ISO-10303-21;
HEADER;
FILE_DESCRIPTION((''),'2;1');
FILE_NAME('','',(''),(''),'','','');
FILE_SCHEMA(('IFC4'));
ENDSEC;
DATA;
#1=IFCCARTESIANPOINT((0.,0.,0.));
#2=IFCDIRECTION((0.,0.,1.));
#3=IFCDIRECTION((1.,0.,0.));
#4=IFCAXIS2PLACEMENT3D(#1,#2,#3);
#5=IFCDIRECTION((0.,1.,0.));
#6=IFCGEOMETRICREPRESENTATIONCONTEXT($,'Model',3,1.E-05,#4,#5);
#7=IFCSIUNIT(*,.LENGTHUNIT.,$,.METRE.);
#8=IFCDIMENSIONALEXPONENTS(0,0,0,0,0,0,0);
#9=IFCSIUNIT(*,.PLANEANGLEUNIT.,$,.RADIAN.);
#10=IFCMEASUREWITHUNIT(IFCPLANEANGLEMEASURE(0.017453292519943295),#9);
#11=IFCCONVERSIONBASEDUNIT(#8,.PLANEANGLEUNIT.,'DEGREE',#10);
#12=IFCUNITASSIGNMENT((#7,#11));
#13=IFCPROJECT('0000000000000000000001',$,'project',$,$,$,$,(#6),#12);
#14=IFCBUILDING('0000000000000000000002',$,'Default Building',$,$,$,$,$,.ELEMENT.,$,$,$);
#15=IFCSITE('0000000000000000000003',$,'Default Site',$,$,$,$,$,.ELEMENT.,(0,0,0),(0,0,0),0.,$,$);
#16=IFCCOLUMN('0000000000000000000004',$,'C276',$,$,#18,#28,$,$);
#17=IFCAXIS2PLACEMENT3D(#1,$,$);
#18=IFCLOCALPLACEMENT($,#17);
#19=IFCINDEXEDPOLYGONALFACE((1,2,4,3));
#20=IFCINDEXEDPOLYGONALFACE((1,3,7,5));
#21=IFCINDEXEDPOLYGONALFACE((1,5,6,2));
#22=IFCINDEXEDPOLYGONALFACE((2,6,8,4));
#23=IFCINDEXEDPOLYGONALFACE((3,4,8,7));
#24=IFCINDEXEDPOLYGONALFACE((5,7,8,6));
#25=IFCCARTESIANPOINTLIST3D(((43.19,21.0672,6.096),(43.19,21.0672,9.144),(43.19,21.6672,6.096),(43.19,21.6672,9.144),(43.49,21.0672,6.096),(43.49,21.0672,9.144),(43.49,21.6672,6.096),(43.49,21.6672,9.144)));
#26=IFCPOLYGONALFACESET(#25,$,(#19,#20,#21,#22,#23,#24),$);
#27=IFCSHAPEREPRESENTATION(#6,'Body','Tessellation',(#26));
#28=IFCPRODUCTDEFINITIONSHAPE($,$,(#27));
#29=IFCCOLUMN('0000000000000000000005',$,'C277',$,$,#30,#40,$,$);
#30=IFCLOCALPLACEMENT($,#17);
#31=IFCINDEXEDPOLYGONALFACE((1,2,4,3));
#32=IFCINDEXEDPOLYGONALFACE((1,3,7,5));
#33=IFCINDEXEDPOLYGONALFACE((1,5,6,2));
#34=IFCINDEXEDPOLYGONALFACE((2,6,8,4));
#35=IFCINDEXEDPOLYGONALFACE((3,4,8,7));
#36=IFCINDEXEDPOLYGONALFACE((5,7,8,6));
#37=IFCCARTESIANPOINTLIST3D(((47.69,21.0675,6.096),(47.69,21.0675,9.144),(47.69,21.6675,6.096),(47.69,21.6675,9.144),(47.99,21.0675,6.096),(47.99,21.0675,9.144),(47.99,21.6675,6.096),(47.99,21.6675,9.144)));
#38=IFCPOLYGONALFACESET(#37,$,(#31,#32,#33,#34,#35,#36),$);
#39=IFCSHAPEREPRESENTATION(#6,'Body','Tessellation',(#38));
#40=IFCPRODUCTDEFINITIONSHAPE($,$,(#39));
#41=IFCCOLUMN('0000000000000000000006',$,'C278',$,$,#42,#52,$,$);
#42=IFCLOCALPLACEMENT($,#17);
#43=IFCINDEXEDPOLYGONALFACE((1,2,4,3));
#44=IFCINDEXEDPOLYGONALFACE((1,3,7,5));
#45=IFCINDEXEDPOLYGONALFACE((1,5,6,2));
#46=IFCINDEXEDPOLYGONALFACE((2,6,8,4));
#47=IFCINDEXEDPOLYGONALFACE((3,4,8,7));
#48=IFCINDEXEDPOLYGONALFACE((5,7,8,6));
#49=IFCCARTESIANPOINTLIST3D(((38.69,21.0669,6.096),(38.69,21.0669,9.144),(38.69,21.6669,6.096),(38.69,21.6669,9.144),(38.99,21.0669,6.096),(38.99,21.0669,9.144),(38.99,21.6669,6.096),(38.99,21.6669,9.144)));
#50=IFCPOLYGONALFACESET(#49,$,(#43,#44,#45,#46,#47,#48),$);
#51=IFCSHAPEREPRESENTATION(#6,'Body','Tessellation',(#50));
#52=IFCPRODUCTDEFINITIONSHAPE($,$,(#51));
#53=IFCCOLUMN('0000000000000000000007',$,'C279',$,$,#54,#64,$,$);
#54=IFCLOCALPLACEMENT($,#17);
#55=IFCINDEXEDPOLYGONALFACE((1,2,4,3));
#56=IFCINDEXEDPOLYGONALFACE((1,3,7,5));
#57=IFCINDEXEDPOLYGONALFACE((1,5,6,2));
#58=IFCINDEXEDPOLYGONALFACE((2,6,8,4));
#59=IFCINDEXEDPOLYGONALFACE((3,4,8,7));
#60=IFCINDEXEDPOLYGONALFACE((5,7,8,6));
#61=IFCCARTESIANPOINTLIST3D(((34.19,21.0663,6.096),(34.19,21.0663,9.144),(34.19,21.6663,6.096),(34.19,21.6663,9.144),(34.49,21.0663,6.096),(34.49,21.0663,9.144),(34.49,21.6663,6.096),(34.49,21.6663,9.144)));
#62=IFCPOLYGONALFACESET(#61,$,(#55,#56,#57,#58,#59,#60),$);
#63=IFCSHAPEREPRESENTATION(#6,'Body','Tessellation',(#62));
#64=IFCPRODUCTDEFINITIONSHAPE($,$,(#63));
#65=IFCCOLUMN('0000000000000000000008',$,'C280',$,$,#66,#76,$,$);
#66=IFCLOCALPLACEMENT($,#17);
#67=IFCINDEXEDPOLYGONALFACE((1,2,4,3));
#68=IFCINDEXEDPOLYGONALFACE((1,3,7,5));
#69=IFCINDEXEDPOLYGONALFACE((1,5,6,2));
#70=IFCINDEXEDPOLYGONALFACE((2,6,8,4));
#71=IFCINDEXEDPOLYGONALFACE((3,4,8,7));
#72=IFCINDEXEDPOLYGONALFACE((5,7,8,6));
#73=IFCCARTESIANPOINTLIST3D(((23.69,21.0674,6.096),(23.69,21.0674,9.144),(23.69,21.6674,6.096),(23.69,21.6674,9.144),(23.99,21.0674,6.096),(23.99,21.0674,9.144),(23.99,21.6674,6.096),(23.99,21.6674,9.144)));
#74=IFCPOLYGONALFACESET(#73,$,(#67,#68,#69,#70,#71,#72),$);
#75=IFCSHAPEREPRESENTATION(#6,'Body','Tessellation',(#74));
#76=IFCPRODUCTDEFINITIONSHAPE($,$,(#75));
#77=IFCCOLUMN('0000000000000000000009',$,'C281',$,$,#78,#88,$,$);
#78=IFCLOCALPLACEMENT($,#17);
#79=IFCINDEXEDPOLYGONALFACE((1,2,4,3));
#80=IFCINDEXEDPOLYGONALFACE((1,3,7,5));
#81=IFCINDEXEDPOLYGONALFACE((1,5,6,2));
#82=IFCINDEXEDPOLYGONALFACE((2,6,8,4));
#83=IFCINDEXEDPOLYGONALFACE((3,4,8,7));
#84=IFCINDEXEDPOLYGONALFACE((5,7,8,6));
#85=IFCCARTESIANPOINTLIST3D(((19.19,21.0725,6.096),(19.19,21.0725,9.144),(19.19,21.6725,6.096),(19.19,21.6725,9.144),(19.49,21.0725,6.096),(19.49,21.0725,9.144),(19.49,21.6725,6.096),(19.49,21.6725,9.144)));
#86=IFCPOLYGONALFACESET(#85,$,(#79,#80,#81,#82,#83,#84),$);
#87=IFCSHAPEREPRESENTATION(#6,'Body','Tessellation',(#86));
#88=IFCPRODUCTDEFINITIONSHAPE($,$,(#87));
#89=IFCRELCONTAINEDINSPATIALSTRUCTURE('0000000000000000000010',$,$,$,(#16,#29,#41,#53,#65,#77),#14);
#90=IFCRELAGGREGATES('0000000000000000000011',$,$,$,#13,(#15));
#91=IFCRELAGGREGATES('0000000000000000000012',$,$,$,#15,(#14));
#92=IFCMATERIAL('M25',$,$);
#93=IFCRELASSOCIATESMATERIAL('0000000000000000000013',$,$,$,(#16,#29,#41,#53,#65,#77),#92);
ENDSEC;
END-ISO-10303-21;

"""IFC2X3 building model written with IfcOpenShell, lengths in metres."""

from ifc_helpers import new_model, entity, si_unit, converted_unit, direction, frame, frame_2d, origin_with_axes, place, context, project, spatial, rectangle, extrude, material, element, save


model = new_model("IFC2X3")

# Units and contexts
model_context = context("Model", 3, precision=1e-05, world=origin_with_axes(), true_north=direction((0.0, 1.0, 0.0)))
ifc_project = project(units=[si_unit("LENGTHUNIT", "METRE"), converted_unit("PLANEANGLEUNIT", "DEGREE", entity("IfcPlaneAngleMeasure", 0.017453292519943295), si_unit("PLANEANGLEUNIT", "RADIAN"), dimensions=[0, 0, 0, 0, 0, 0, 0])], contexts=[model_context])

# Site, building
site = spatial("IfcSite", under=ifc_project, Name="Default Site", CompositionType="ELEMENT", RefLatitude=(0, 0, 0), RefLongitude=(0, 0, 0), RefElevation=0.0)
building = spatial("IfcBuilding", under=site, Name="Default Building", CompositionType="ELEMENT")

# Columns
ifc_material = material(Name="M25")
placement = place(None, origin_with_axes())
element("IfcColumn", 1, at=placement, inside=building, material=ifc_material, Name="C276", context=model_context, shape_type="SweptSolid", body=[
    extrude(rectangle(XDim=0.3, YDim=0.6, at=frame_2d((0.0, 0.0), x_axis=(1.0, 0.0, 0.0))), frame((43.34, 21.3672, 6.096), z_axis=(0.0, 0.0, 1.0), x_axis=(1.0, 0.0, 0.0)), (0.0, 0.0, 1.0), 3.048),
])
element("IfcColumn", 2, at=placement, inside=building, material=ifc_material, Name="C277", context=model_context, shape_type="SweptSolid", body=[
    extrude(rectangle(XDim=0.3, YDim=0.6, at=frame_2d((0.0, 0.0), x_axis=(1.0, 0.0, 0.0))), frame((47.84, 21.3675, 6.096), z_axis=(0.0, 0.0, 1.0), x_axis=(1.0, 0.0, 0.0)), (0.0, 0.0, 1.0), 3.048),
])
element("IfcColumn", 3, at=placement, inside=building, material=ifc_material, Name="C278", context=model_context, shape_type="SweptSolid", body=[
    extrude(rectangle(XDim=0.3, YDim=0.6, at=frame_2d((0.0, 0.0), x_axis=(1.0, 0.0, 0.0))), frame((38.84, 21.3669, 6.096), z_axis=(0.0, 0.0, 1.0), x_axis=(1.0, 0.0, 0.0)), (0.0, 0.0, 1.0), 3.048),
])
element("IfcColumn", 4, at=placement, inside=building, material=ifc_material, Name="C279", context=model_context, shape_type="SweptSolid", body=[
    extrude(rectangle(XDim=0.3, YDim=0.6, at=frame_2d((0.0, 0.0), x_axis=(1.0, 0.0, 0.0))), frame((34.34, 21.3663, 6.096), z_axis=(0.0, 0.0, 1.0), x_axis=(1.0, 0.0, 0.0)), (0.0, 0.0, 1.0), 3.048),
])
element("IfcColumn", 5, at=placement, inside=building, material=ifc_material, Name="C280", context=model_context, shape_type="SweptSolid", body=[
    extrude(rectangle(XDim=0.3, YDim=0.6, at=frame_2d((0.0, 0.0), x_axis=(1.0, 0.0, 0.0))), frame((23.84, 21.3674, 6.096), z_axis=(0.0, 0.0, 1.0), x_axis=(1.0, 0.0, 0.0)), (0.0, 0.0, 1.0), 3.048),
])
element("IfcColumn", 6, at=placement, inside=building, material=ifc_material, Name="C281", context=model_context, shape_type="SweptSolid", body=[
    extrude(rectangle(XDim=0.3, YDim=0.6, at=frame_2d((0.0, 0.0), x_axis=(1.0, 0.0, 0.0))), frame((19.34, 21.3725, 6.096), z_axis=(0.0, 0.0, 1.0), x_axis=(1.0, 0.0, 0.0)), (0.0, 0.0, 1.0), 3.048),
])

save(model, "model.ifc")
